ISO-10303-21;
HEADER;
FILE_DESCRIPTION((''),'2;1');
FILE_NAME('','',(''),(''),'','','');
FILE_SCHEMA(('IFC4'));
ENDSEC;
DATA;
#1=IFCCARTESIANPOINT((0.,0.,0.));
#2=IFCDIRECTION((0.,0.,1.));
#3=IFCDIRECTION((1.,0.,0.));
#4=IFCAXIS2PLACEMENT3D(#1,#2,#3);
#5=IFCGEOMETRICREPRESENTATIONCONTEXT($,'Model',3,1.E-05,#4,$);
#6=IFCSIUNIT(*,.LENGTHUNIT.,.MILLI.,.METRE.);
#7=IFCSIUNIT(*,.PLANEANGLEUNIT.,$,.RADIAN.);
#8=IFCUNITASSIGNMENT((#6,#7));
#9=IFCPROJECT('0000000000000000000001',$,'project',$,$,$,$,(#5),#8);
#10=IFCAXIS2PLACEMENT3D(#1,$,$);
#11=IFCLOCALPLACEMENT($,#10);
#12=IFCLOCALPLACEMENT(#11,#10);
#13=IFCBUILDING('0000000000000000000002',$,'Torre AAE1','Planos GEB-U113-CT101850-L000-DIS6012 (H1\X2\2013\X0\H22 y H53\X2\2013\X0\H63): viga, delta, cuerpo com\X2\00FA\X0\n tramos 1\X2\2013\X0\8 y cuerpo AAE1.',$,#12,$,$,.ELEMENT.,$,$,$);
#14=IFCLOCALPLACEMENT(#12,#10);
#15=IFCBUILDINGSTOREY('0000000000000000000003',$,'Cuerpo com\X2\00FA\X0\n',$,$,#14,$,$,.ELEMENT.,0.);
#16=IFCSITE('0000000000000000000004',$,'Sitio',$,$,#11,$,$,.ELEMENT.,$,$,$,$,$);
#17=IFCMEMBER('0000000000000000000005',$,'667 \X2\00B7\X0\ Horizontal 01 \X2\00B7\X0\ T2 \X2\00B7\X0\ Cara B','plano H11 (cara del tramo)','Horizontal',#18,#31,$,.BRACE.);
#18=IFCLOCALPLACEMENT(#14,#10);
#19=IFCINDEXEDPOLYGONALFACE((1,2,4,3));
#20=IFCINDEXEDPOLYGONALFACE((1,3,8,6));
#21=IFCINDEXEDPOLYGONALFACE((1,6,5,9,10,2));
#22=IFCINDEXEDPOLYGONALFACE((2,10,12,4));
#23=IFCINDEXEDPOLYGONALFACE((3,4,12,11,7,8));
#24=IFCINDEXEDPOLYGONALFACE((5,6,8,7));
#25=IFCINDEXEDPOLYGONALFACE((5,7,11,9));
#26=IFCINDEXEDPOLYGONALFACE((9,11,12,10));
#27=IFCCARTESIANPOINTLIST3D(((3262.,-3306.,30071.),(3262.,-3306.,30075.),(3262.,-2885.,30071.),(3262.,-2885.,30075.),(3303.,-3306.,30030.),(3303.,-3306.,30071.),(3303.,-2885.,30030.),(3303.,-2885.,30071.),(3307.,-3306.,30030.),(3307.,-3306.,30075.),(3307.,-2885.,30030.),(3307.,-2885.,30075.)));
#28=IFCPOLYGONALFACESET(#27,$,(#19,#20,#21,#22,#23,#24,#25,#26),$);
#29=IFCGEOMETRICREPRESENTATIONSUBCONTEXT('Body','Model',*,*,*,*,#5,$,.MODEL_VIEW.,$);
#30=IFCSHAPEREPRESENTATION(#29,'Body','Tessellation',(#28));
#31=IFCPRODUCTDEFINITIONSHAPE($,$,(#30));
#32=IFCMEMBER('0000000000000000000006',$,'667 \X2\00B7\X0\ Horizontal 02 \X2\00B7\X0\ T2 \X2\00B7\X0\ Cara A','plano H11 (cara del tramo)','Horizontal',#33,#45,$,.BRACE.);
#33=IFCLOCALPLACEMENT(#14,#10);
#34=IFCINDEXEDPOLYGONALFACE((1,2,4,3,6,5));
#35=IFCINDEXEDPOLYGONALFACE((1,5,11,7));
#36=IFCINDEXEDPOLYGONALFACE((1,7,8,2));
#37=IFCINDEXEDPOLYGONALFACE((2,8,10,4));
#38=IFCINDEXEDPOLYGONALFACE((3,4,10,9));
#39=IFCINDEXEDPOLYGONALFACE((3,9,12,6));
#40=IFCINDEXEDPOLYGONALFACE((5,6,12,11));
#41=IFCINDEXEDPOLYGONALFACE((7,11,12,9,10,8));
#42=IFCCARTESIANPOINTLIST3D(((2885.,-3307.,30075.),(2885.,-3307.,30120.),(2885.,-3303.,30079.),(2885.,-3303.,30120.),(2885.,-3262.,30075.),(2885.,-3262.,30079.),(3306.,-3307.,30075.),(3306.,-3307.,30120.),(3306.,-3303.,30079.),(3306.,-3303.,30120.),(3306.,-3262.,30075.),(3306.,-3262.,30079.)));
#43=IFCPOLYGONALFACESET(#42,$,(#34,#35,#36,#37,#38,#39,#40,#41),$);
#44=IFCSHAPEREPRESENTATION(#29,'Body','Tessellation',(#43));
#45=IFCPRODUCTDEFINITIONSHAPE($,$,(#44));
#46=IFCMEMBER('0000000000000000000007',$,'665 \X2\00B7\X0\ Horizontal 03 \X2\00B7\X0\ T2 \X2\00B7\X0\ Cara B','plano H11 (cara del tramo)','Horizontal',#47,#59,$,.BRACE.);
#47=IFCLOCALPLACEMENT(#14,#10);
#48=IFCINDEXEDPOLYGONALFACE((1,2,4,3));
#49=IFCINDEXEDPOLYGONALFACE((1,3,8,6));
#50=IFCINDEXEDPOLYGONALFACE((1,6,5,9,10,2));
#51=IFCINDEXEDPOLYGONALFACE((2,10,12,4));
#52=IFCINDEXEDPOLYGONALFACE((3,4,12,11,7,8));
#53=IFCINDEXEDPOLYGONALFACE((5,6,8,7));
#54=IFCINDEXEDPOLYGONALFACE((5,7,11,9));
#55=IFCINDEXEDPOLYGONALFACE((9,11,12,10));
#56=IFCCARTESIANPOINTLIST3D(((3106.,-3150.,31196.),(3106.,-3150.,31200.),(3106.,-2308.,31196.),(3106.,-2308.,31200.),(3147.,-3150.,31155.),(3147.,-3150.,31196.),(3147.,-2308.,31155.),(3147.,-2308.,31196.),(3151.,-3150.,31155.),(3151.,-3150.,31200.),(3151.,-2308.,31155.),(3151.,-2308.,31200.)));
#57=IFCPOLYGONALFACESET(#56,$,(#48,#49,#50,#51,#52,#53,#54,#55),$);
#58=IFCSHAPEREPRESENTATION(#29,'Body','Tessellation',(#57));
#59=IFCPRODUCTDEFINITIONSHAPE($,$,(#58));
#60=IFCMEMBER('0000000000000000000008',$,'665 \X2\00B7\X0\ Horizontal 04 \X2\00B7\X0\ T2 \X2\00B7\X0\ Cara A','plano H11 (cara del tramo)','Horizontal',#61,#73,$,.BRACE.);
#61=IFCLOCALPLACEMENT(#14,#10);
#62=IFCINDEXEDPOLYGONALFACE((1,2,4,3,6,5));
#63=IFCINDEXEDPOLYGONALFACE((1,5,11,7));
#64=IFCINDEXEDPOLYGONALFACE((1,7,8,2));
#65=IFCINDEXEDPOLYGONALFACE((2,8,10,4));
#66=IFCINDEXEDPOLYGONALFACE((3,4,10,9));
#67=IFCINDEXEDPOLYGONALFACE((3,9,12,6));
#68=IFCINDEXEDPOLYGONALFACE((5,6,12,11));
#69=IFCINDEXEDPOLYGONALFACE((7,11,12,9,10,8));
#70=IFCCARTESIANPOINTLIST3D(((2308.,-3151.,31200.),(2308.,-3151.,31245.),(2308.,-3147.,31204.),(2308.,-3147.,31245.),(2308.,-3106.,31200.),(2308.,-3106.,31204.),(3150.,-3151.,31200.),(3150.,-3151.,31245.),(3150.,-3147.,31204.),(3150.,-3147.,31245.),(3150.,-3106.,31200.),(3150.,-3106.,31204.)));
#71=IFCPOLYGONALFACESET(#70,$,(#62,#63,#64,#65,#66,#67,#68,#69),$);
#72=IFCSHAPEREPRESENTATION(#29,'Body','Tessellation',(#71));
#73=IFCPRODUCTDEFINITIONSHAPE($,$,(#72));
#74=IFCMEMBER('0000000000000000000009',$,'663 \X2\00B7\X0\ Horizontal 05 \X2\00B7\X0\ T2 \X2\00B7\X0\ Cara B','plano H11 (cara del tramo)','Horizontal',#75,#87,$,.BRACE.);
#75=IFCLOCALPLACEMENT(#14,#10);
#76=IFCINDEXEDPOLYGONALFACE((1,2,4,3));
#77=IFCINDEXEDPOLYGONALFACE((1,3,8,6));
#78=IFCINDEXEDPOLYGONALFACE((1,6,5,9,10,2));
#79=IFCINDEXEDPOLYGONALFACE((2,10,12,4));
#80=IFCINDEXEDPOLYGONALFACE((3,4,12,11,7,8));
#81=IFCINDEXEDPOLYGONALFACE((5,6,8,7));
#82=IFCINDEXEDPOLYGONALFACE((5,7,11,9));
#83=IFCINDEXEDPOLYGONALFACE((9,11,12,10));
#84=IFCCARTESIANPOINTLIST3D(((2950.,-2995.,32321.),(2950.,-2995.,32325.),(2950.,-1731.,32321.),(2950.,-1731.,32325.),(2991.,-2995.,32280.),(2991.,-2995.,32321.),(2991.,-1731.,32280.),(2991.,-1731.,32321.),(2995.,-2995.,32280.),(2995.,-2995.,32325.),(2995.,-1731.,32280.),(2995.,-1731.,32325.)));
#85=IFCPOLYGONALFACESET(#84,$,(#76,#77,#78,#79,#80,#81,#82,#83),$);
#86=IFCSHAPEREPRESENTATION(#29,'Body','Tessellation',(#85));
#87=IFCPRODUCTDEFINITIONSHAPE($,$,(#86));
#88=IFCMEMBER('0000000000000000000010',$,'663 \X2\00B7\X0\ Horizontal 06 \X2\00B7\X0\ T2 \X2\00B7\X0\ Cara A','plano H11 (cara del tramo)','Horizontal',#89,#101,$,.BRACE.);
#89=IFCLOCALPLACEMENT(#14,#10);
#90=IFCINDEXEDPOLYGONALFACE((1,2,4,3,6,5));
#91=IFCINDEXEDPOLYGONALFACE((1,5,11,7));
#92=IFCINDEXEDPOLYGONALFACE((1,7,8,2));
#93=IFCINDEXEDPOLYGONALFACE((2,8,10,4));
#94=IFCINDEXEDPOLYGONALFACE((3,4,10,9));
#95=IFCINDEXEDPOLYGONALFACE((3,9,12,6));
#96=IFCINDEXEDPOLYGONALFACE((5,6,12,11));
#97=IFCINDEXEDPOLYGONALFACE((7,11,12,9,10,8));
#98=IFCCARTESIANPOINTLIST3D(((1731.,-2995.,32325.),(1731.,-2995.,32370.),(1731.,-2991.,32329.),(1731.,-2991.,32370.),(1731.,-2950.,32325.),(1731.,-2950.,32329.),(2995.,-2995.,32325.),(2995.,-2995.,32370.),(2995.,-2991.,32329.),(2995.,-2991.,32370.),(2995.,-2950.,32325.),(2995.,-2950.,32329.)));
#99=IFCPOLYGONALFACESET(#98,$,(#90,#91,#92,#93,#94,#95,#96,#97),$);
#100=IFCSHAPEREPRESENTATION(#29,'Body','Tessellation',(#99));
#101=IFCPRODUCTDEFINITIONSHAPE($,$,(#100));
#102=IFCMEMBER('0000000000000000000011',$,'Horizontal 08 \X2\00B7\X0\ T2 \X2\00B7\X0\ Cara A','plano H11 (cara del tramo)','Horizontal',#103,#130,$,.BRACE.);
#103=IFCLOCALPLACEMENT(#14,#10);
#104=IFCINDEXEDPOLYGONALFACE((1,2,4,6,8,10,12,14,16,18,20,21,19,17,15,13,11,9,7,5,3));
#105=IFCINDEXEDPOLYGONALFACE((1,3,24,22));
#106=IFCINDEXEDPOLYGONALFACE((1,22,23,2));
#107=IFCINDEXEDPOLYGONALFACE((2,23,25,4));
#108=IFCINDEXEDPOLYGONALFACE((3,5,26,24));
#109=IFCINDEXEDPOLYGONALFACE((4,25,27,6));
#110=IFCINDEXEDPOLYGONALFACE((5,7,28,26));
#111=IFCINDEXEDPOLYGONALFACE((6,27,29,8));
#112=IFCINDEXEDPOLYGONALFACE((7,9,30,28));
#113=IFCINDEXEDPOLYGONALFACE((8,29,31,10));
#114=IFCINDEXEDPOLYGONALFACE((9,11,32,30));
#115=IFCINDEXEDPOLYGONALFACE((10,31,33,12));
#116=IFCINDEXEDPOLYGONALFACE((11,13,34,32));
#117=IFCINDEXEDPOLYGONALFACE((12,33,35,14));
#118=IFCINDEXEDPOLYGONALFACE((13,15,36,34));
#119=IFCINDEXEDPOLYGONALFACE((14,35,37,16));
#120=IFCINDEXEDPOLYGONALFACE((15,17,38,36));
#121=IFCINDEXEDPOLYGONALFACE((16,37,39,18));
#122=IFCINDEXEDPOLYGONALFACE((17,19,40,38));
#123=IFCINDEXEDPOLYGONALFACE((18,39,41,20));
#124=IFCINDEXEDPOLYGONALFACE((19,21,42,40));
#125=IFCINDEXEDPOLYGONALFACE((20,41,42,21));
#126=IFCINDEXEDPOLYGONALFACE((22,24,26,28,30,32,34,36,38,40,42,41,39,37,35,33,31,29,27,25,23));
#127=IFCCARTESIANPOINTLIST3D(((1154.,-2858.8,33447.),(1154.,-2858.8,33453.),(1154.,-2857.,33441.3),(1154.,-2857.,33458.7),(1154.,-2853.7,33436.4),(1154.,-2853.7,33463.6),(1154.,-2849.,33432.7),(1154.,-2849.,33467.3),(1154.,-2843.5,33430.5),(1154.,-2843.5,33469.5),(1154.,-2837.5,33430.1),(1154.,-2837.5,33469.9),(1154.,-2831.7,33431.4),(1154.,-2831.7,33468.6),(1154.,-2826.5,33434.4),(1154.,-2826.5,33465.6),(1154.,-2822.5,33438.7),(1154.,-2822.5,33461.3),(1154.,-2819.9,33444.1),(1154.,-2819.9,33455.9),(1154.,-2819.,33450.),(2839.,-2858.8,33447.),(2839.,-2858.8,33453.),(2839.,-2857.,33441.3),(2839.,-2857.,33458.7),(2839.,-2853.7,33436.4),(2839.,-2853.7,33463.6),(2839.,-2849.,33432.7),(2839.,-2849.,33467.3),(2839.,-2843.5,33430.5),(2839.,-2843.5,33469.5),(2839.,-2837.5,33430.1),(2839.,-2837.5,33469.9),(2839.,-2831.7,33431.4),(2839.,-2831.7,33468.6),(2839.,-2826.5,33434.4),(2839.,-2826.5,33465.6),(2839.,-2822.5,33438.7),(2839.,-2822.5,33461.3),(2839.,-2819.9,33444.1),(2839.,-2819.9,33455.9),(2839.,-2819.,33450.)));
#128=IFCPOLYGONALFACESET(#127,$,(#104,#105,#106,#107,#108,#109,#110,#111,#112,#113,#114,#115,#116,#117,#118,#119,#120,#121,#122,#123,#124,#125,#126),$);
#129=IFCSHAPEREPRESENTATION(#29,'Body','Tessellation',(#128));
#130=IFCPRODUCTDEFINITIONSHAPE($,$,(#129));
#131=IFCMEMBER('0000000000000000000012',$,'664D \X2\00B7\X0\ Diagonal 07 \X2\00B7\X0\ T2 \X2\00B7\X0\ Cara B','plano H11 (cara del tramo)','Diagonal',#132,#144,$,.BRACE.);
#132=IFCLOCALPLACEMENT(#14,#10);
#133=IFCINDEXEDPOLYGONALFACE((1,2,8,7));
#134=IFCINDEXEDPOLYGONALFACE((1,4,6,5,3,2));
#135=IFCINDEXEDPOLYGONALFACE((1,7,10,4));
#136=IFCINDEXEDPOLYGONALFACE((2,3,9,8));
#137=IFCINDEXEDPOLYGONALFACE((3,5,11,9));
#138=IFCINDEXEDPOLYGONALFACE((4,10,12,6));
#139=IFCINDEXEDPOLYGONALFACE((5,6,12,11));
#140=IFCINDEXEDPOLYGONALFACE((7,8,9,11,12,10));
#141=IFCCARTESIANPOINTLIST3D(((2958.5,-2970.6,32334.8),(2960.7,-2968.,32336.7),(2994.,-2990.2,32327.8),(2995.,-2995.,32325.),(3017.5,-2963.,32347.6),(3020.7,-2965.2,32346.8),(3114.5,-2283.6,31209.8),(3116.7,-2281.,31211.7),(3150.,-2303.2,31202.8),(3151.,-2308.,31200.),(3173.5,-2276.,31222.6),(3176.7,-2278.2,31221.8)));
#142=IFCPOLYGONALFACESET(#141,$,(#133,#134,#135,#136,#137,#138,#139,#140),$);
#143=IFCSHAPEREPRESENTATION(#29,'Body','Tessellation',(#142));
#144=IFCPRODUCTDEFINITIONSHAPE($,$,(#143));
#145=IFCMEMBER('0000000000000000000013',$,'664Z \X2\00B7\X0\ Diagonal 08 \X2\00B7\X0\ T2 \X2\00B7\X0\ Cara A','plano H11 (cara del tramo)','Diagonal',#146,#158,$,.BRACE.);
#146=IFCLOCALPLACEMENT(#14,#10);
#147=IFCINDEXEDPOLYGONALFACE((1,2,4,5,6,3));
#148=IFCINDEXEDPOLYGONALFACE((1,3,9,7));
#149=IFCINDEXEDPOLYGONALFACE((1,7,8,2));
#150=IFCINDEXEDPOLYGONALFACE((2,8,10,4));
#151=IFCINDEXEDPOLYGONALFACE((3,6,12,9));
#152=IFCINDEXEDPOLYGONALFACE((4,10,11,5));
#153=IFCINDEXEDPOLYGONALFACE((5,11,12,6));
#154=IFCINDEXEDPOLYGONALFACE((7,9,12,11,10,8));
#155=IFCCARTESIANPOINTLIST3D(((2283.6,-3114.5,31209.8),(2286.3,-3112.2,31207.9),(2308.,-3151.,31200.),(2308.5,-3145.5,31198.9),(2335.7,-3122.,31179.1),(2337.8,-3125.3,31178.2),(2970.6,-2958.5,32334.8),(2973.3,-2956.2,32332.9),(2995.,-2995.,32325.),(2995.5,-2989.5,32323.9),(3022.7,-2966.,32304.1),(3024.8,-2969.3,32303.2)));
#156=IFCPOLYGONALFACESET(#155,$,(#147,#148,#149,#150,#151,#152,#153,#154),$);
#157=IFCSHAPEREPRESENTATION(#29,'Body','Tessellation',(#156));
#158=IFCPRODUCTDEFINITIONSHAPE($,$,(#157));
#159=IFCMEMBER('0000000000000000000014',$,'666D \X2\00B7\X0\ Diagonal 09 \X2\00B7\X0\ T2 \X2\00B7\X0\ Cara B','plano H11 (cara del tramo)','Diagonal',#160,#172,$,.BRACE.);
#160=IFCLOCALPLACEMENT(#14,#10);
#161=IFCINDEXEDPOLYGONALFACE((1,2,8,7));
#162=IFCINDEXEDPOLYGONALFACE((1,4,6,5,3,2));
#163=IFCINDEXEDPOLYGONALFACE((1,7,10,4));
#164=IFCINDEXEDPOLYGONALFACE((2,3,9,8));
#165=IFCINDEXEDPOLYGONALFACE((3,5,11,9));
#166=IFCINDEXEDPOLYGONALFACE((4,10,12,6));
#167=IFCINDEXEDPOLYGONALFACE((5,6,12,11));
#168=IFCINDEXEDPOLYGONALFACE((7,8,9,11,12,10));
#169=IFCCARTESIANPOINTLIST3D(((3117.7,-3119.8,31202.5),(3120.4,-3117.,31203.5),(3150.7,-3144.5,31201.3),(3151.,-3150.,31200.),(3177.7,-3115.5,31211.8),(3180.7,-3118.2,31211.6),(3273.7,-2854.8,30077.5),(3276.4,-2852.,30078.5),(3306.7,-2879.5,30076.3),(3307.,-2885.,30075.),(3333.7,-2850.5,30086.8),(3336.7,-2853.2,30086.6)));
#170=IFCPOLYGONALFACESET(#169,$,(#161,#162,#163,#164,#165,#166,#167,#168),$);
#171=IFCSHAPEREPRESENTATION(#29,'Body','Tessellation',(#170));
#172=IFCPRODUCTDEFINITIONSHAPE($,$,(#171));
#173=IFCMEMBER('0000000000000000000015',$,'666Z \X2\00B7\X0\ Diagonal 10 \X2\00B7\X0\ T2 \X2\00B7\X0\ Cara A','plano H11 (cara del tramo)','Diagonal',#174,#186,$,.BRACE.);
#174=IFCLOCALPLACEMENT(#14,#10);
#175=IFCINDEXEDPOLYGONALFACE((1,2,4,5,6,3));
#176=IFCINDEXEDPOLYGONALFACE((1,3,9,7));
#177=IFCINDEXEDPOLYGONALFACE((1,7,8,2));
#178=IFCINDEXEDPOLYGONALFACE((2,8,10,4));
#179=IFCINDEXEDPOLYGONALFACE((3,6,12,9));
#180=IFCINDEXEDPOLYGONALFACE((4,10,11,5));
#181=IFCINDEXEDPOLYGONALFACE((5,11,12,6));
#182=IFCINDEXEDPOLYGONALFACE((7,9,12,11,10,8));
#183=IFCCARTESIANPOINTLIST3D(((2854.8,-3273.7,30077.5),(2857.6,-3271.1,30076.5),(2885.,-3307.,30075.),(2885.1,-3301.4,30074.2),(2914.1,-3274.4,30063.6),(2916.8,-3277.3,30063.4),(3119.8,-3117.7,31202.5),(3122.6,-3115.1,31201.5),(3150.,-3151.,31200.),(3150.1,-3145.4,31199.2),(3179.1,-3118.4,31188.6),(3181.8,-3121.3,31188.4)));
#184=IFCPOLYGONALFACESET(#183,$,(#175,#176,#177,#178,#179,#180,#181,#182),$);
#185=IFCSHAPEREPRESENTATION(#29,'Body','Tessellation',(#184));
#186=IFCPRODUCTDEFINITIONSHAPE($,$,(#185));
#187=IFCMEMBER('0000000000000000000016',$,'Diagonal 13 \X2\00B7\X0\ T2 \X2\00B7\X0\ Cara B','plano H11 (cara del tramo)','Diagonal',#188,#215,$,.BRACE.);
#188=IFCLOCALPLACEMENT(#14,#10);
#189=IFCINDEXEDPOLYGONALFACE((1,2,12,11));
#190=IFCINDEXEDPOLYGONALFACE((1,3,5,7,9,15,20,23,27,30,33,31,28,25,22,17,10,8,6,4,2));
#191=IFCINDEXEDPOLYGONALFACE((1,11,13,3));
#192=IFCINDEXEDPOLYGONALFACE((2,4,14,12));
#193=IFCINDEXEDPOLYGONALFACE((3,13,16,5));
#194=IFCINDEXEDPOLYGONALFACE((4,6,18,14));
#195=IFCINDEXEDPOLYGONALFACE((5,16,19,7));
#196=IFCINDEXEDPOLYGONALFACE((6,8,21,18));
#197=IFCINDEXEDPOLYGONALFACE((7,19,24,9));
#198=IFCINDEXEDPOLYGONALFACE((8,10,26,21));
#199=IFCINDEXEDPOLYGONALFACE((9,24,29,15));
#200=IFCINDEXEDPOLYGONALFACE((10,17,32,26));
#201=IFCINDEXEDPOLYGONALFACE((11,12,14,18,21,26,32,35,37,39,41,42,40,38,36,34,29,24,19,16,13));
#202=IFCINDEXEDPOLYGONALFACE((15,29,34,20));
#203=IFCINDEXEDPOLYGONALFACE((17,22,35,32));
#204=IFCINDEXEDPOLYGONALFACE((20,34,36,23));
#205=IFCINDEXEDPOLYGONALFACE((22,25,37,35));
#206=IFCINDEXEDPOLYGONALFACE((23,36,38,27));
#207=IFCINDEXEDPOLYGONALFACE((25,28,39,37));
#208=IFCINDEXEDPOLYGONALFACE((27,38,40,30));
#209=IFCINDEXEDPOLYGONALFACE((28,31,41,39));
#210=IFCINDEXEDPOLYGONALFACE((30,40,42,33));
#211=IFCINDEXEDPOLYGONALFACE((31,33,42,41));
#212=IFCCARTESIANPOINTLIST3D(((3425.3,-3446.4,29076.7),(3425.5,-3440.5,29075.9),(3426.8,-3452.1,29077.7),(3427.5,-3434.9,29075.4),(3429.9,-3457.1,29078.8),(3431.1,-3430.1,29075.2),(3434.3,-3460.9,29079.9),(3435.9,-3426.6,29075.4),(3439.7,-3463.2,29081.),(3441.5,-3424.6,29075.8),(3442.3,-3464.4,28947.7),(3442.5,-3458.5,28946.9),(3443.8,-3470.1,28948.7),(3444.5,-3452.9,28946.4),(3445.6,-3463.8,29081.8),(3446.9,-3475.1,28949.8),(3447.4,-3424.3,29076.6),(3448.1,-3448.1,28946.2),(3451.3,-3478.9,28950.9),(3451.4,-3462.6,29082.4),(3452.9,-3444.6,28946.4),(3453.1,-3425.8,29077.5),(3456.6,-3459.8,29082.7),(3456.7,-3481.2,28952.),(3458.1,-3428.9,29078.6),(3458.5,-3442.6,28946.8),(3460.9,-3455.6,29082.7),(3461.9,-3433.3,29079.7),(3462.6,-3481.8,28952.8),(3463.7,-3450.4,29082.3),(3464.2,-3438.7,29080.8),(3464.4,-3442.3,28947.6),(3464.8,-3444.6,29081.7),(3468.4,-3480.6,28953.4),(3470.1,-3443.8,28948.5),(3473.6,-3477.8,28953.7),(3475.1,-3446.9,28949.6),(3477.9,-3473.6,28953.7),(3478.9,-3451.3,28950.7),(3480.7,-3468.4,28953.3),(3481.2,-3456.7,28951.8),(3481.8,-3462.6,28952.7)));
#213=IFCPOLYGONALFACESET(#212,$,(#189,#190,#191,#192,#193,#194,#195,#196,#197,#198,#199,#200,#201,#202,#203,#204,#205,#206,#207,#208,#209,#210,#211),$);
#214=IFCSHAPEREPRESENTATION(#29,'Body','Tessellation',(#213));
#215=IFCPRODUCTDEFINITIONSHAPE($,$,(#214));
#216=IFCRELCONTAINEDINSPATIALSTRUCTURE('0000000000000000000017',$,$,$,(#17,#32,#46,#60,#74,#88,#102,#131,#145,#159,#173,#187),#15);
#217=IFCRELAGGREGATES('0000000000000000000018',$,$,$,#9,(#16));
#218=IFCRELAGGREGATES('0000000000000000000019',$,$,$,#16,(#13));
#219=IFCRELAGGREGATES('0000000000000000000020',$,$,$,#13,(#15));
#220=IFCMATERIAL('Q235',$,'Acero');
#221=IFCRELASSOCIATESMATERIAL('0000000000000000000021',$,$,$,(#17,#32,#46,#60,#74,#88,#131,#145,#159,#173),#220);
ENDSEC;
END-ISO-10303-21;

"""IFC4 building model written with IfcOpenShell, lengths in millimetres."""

from ifc_helpers import new_model, si_unit, frame, frame_2d, origin, origin_with_axes, place, context, subcontext, project, spatial, circle, l_section, extrude, material, element, save


model = new_model("IFC4")

# Units and contexts
model_context = context("Model", 3, precision=1e-05, world=origin_with_axes())
body_context = subcontext(model_context, "Body", "Model", "MODEL_VIEW")
ifc_project = project(units=[si_unit("LENGTHUNIT", "METRE", prefix="MILLI"), si_unit("PLANEANGLEUNIT", "RADIAN")], contexts=[model_context])

# Site, building, storey
site_placement = place(None, origin())
site = spatial("IfcSite", under=ifc_project, at=site_placement, Name="Sitio", CompositionType="ELEMENT")
building_placement = place(site_placement, origin())
building = spatial("IfcBuilding", under=site, at=building_placement, Name="Torre AAE1", Description="Planos GEB-U113-CT101850-L000-DIS6012 (H1–H22 y H53–H63): viga, delta, cuerpo común tramos 1–8 y cuerpo AAE1.", CompositionType="ELEMENT")
storey_placement = place(building_placement, origin())
storey = spatial("IfcBuildingStorey", under=building, at=storey_placement, Name="Cuerpo común", CompositionType="ELEMENT", Elevation=0.0)

# Members
ifc_material_1 = material(Name="Q235", Category="Acero")
for number, where, z_axis, x_axis, name in (
    (1, (3307.0, -2885.0, 30075.0), (0.0, -1.0, 0.0), (-1.0, 0.0, 0.0), "667 · Horizontal 01 · T2 · Cara B"),
    (2, (2885.0, -3307.0, 30075.0), (1.0, 0.0, 0.0), (0.0, 1.0, 0.0), "667 · Horizontal 02 · T2 · Cara A"),
):
    element("IfcMember", number, at=place(storey_placement, frame(where, z_axis=z_axis, x_axis=x_axis)), inside=storey, material=ifc_material_1, Name=name, Description="plano H11 (cara del tramo)", ObjectType="Horizontal", PredefinedType="BRACE", context=body_context, shape_type="SweptSolid", body=[
        extrude(l_section(Depth=45.0, Width=45.0, Thickness=4.0, at=frame_2d((22.5, 22.5))), None, (0.0, 0.0, 1.0), 421.0),
    ])
for number, where, z_axis, x_axis, name in (
    (3, (3151.0, -2308.0, 31200.0), (0.0, -1.0, 0.0), (-1.0, 0.0, 0.0), "665 · Horizontal 03 · T2 · Cara B"),
    (4, (2308.0, -3151.0, 31200.0), (1.0, 0.0, 0.0), (0.0, 1.0, 0.0), "665 · Horizontal 04 · T2 · Cara A"),
):
    element("IfcMember", number, at=place(storey_placement, frame(where, z_axis=z_axis, x_axis=x_axis)), inside=storey, material=ifc_material_1, Name=name, Description="plano H11 (cara del tramo)", ObjectType="Horizontal", PredefinedType="BRACE", context=body_context, shape_type="SweptSolid", body=[
        extrude(l_section(Depth=45.0, Width=45.0, Thickness=4.0, at=frame_2d((22.5, 22.5))), None, (0.0, 0.0, 1.0), 842.0),
    ])
for number, where, z_axis, x_axis, name in (
    (5, (2995.0, -1731.0, 32325.0), (0.0, -1.0, 0.0), (-1.0, 0.0, 0.0), "663 · Horizontal 05 · T2 · Cara B"),
    (6, (1731.0, -2995.0, 32325.0), (1.0, 0.0, 0.0), (0.0, 1.0, 0.0), "663 · Horizontal 06 · T2 · Cara A"),
):
    element("IfcMember", number, at=place(storey_placement, frame(where, z_axis=z_axis, x_axis=x_axis)), inside=storey, material=ifc_material_1, Name=name, Description="plano H11 (cara del tramo)", ObjectType="Horizontal", PredefinedType="BRACE", context=body_context, shape_type="SweptSolid", body=[
        extrude(l_section(Depth=45.0, Width=45.0, Thickness=4.0, at=frame_2d((22.5, 22.5))), None, (0.0, 0.0, 1.0), 1264.0),
    ])
member_1_placement = place(storey_placement, frame((1154.0, -2839.0, 33450.0), z_axis=(1.0, 0.0, 0.0), x_axis=(0.0, 1.0, 0.0)))
element("IfcMember", 7, at=member_1_placement, inside=storey, Name="Horizontal 08 · T2 · Cara A", Description="plano H11 (cara del tramo)", ObjectType="Horizontal", PredefinedType="BRACE", context=body_context, shape_type="SweptSolid", body=[
    extrude(circle(Radius=20.0), None, (0.0, 0.0, 1.0), 1685.0),
])
for number, where, z_axis, x_axis, name in (
    (8, (2995.0, -2995.0, 32325.0), (0.117525, 0.517562, -0.847536), (-0.812003, 0.541404, 0.21802), "664D · Diagonal 07 · T2 · Cara B"),
    (9, (2995.0, -2995.0, 32325.0), (-0.517562, -0.117525, -0.847536), (-0.541404, 0.812003, 0.21802), "664Z · Diagonal 08 · T2 · Cara A"),
):
    element("IfcMember", number, at=place(storey_placement, frame(where, z_axis=z_axis, x_axis=x_axis)), inside=storey, material=ifc_material_1, Name=name, Description="plano H11 (cara del tramo)", ObjectType="Diagonal", PredefinedType="BRACE", context=body_context, shape_type="SweptSolid", body=[
        extrude(l_section(Depth=45.0, Width=45.0, Thickness=4.0, at=frame_2d((22.5, 22.5))), None, (0.0, 0.0, 1.0), 1327.4),
    ])
for number, where, z_axis, x_axis, name in (
    (10, (3151.0, -3150.0, 31200.0), (0.13376, 0.22722, -0.964614), (-0.739529, 0.670835, 0.055471), "666D · Diagonal 09 · T2 · Cara B"),
    (11, (3150.0, -3151.0, 31200.0), (-0.22722, -0.13376, -0.964614), (-0.670835, 0.739529, 0.055471), "666Z · Diagonal 10 · T2 · Cara A"),
):
    element("IfcMember", number, at=place(storey_placement, frame(where, z_axis=z_axis, x_axis=x_axis)), inside=storey, material=ifc_material_1, Name=name, Description="plano H11 (cara del tramo)", ObjectType="Diagonal", PredefinedType="BRACE", context=body_context, shape_type="SweptSolid", body=[
        extrude(l_section(Depth=45.0, Width=45.0, Thickness=4.0, at=frame_2d((22.5, 22.5))), None, (0.0, 0.0, 1.0), 1166.3),
    ])
member_2_placement = place(storey_placement, frame((3445.0, -3444.0, 29079.0), z_axis=(0.129421, -0.137034, -0.982075), x_axis=(-0.695225, 0.69366, -0.188409)))
element("IfcMember", 12, at=member_2_placement, inside=storey, Name="Diagonal 13 · T2 · Cara B", Description="plano H11 (cara del tramo)", ObjectType="Diagonal", PredefinedType="BRACE", context=body_context, shape_type="SweptSolid", body=[
    extrude(circle(Radius=20.0), None, (0.0, 0.0, 1.0), 131.4),
])

save(model, "model.ifc")
